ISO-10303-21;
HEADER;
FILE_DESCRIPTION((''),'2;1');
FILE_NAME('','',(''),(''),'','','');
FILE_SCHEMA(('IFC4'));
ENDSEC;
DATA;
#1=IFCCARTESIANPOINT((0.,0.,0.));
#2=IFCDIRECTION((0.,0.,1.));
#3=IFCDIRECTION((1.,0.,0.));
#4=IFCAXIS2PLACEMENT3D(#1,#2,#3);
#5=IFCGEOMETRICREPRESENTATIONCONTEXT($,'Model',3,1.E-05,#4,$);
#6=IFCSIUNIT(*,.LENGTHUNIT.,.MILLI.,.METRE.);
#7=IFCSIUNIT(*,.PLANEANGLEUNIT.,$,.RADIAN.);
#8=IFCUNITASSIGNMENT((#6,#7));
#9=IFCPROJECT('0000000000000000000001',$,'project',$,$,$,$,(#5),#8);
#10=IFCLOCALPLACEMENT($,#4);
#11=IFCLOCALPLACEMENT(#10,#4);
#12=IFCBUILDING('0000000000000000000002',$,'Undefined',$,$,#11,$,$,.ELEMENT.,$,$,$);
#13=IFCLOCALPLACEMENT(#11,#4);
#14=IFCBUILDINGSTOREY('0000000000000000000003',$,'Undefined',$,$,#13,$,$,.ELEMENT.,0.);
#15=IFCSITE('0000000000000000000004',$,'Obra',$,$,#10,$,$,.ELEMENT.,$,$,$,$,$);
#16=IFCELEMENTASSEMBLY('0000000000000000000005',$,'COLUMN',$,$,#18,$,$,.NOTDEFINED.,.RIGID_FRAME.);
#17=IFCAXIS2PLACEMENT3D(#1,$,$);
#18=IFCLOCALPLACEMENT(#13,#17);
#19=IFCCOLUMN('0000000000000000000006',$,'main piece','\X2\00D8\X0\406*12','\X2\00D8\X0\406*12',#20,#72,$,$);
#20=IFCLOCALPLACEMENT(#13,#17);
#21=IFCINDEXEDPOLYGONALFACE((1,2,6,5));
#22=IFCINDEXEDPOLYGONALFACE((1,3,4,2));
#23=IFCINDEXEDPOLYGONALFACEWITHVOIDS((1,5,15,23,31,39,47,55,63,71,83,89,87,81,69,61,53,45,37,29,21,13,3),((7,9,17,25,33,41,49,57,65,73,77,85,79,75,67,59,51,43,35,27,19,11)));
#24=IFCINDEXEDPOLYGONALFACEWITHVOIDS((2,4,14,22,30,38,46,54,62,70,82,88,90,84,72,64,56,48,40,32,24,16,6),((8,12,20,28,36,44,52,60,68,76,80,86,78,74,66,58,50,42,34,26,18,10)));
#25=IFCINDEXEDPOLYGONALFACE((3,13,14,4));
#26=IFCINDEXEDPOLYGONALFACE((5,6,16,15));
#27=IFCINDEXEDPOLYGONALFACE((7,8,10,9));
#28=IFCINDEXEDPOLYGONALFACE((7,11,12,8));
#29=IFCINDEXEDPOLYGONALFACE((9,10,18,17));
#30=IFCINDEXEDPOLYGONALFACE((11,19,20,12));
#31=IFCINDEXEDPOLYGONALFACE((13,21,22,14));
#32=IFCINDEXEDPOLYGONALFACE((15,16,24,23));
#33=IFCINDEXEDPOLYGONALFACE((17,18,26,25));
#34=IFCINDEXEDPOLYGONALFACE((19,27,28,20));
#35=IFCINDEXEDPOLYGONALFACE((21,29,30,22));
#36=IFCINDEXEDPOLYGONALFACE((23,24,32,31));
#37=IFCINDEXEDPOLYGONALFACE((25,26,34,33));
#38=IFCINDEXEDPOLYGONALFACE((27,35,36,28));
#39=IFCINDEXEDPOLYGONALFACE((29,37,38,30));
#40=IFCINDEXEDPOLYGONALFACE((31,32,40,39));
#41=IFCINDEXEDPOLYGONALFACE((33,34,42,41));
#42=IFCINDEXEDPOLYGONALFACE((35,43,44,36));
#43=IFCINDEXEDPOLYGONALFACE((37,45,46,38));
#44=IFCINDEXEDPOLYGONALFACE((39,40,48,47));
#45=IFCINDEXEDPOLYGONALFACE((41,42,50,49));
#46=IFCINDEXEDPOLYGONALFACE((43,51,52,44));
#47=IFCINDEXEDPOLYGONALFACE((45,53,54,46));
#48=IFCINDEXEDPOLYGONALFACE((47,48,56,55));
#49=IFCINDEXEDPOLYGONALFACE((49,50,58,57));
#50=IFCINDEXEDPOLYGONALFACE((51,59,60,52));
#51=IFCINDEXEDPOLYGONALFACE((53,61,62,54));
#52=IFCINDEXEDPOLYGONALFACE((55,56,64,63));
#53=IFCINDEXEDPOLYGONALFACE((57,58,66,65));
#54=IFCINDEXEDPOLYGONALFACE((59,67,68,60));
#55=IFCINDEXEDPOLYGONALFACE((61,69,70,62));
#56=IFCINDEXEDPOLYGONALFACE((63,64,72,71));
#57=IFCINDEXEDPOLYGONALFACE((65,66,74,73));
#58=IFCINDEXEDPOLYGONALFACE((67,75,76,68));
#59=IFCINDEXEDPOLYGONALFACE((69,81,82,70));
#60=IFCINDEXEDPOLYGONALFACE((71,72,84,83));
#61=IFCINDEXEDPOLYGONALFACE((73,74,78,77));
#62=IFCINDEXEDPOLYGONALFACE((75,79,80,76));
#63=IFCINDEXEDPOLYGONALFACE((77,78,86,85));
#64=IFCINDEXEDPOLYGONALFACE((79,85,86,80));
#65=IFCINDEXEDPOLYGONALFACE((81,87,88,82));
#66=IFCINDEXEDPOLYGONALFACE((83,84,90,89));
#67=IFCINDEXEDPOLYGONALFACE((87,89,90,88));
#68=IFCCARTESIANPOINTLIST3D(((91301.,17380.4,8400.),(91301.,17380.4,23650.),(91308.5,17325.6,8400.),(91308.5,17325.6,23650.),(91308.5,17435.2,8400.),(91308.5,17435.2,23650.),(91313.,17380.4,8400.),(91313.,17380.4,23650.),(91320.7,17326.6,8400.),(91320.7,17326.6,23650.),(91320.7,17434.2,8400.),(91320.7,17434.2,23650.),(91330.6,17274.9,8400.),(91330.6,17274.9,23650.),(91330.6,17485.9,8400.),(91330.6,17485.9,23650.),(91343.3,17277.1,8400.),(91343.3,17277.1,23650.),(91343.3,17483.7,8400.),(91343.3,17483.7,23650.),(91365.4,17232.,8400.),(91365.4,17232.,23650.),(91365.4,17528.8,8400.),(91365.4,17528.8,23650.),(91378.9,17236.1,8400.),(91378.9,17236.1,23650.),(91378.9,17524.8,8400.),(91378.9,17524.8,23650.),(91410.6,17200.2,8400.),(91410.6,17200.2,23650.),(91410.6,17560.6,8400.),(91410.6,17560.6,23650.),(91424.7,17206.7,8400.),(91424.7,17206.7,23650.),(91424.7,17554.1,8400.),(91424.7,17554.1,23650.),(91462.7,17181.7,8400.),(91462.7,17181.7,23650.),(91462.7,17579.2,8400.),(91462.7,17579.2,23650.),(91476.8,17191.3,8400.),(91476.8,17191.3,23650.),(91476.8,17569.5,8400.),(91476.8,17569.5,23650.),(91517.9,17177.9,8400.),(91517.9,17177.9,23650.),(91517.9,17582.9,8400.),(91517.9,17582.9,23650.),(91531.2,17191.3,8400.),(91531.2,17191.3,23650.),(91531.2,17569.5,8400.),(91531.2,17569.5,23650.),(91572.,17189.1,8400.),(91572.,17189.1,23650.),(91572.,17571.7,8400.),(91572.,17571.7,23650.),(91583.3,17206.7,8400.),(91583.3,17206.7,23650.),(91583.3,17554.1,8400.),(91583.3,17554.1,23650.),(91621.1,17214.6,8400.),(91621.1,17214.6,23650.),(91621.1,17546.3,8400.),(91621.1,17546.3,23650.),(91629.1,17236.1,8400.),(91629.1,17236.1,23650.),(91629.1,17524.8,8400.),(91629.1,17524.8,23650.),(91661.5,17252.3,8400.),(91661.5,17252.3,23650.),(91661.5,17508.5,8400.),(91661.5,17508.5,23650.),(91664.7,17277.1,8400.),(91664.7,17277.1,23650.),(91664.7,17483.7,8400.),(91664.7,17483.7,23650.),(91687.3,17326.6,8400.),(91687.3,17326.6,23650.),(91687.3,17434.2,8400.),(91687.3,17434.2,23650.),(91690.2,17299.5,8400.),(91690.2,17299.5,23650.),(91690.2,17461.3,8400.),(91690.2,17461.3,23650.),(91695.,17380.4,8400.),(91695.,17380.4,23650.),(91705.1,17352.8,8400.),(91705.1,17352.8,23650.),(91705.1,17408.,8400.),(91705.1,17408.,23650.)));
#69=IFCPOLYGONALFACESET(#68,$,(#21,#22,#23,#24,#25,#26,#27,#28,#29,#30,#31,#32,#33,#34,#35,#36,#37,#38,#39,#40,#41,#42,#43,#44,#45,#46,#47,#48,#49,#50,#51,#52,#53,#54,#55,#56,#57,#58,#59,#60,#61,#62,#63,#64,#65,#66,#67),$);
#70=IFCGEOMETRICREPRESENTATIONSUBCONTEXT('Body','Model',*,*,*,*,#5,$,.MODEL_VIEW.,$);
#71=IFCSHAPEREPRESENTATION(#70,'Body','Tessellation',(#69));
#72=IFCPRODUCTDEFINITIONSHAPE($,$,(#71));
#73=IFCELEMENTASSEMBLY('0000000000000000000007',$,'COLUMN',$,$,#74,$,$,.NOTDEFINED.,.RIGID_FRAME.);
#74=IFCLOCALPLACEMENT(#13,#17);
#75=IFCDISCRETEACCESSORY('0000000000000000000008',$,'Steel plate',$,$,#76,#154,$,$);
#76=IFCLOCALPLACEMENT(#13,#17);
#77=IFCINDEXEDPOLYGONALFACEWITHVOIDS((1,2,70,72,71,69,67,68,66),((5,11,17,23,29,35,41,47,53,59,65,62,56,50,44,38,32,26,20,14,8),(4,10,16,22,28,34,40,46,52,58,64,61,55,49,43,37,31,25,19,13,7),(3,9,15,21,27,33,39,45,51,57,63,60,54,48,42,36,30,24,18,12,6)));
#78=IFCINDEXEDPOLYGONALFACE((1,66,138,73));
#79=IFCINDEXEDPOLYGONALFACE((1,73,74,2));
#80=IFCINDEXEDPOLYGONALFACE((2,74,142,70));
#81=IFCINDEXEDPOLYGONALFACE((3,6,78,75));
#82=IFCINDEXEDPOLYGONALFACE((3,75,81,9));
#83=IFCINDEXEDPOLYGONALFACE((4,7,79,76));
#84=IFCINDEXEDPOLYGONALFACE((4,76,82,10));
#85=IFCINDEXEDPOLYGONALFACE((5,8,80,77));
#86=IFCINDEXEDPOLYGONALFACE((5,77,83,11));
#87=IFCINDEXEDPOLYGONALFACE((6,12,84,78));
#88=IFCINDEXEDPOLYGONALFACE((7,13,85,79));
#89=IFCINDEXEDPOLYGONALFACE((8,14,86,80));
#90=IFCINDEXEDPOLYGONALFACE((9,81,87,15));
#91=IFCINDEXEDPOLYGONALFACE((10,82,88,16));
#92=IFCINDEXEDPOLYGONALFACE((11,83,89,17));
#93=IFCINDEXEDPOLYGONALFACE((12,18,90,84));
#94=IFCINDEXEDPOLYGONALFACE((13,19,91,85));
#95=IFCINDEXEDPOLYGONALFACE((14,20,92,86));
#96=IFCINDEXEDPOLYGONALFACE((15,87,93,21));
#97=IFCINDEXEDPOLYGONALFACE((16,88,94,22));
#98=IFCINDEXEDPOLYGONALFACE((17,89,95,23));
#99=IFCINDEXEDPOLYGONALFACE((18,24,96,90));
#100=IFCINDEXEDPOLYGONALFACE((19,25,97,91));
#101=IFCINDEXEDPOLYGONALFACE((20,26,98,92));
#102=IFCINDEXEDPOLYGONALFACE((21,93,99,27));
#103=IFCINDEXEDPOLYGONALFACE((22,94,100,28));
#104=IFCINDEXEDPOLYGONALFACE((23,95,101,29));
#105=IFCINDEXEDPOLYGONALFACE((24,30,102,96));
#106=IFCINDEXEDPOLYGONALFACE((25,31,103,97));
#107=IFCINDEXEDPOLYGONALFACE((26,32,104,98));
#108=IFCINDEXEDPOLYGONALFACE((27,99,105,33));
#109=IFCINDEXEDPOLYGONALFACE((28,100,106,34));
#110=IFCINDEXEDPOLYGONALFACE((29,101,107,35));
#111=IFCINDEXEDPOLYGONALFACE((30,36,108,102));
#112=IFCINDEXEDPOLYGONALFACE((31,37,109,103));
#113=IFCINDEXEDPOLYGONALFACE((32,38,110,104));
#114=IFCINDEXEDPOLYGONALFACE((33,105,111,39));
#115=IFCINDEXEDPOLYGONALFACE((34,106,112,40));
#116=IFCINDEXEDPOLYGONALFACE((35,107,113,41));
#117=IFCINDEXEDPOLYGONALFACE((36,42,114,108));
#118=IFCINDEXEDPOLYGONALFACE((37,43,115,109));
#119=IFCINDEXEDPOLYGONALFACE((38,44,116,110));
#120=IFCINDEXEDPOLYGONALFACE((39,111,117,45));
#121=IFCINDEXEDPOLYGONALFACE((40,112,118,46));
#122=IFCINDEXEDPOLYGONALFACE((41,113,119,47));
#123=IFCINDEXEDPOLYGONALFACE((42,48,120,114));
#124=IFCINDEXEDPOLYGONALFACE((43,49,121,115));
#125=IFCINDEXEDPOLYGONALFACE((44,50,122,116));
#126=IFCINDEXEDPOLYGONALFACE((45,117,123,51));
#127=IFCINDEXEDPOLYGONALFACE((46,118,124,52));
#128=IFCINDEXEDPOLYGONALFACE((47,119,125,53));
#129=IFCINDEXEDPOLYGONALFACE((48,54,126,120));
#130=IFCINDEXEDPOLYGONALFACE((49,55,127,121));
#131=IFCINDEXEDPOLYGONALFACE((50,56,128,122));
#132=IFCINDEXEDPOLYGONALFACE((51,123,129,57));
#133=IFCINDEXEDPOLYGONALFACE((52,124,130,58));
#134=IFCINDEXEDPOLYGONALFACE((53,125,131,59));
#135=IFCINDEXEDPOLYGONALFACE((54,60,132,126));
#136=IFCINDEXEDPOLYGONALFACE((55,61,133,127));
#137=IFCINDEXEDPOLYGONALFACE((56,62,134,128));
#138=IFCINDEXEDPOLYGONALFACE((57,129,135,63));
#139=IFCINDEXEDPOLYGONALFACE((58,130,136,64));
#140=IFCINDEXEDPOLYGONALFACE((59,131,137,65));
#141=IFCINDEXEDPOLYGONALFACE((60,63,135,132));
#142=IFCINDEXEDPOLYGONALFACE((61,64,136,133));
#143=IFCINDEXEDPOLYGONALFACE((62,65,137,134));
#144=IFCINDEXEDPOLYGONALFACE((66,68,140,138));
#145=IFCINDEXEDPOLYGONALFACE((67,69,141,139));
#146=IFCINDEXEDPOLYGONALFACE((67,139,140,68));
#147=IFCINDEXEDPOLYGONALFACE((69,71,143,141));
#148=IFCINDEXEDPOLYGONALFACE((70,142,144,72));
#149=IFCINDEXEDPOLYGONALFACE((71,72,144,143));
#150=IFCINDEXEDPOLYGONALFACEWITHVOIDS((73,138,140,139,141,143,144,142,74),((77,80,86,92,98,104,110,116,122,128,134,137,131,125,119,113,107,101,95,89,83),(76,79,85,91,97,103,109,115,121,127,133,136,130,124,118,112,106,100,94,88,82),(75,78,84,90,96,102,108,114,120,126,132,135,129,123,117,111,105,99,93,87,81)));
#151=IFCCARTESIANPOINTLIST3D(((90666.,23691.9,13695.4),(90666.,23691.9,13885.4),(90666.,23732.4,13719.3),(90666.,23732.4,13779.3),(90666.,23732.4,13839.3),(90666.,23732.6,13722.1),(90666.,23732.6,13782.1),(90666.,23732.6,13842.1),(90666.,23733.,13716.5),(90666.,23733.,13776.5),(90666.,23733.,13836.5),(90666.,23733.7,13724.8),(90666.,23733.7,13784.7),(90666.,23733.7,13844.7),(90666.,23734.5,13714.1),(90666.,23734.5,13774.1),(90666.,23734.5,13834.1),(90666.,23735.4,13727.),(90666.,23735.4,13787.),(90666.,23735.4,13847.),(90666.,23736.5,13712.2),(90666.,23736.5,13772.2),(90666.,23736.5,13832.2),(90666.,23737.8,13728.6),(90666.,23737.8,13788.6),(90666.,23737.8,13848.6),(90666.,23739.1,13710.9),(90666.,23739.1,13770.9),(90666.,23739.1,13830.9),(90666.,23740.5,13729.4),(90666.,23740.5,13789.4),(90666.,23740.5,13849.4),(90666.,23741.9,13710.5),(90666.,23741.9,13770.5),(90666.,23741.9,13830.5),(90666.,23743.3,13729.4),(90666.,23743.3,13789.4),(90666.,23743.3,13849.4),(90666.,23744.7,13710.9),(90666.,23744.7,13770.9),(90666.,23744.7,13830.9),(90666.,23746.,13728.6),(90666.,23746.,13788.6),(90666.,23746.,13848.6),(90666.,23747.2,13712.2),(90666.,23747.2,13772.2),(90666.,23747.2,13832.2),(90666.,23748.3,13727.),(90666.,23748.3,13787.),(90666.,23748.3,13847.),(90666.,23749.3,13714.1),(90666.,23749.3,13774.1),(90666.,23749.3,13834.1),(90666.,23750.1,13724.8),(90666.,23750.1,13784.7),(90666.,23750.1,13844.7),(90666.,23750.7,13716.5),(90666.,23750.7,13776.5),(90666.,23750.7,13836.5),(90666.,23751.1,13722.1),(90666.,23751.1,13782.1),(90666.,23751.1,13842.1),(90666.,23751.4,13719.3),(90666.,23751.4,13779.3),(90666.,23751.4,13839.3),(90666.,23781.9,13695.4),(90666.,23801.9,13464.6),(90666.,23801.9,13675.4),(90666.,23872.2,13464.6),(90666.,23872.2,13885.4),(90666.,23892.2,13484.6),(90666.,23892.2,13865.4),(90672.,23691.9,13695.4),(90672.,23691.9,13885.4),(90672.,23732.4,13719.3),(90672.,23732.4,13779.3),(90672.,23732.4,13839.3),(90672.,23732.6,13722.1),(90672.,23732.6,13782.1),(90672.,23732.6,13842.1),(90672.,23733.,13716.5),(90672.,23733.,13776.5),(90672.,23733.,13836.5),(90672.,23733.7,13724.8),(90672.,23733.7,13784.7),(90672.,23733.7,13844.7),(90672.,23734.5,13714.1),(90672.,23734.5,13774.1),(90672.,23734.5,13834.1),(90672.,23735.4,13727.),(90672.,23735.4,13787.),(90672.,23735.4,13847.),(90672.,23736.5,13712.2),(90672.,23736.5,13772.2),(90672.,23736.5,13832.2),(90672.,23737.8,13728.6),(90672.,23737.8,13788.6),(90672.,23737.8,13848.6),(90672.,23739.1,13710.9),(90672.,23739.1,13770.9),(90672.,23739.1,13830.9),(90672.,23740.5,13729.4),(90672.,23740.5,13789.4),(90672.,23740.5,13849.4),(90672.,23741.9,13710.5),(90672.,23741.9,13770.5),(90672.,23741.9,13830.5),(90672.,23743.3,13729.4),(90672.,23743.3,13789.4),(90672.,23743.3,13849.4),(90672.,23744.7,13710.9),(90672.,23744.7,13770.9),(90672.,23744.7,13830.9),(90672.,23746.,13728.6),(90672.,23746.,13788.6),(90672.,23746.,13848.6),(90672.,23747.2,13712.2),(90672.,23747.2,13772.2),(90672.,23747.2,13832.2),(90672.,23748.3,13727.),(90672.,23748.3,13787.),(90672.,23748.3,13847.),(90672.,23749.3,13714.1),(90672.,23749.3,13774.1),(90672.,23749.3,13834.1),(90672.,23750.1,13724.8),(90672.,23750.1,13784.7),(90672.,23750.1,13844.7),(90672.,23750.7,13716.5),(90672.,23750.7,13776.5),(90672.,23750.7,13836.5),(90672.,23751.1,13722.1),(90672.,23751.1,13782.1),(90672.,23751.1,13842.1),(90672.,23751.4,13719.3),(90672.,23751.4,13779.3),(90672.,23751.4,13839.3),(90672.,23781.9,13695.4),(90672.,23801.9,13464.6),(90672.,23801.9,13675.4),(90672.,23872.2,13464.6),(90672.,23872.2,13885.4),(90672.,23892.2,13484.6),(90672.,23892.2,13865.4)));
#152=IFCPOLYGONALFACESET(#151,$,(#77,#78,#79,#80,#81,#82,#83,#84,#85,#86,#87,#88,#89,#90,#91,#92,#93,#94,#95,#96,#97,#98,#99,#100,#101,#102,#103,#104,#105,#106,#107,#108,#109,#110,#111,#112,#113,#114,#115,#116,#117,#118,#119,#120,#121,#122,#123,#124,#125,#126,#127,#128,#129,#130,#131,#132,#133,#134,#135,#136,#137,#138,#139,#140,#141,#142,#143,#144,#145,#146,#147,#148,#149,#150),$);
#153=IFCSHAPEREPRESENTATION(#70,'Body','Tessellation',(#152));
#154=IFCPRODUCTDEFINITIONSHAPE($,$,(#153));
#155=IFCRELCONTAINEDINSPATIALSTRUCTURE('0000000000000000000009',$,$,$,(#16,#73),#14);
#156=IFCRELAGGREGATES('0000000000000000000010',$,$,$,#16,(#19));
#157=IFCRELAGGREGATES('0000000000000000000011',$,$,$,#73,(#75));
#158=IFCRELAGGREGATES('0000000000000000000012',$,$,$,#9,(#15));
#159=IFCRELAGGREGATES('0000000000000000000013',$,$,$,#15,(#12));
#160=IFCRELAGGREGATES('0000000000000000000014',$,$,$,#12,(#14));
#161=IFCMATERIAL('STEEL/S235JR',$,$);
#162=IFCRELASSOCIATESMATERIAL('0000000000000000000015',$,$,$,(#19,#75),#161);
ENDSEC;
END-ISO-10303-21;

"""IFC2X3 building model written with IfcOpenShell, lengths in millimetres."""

from ifc_helpers import new_model, si_unit, frame, origin_with_axes, origin_2d_with_axis, place, context, subcontext, project, spatial, polyline, circle, hollow_circle, outline, extrude, clip, halfspace, source, transform, mapped, material, element, aggregate, save


model = new_model("IFC2X3")

# Units and contexts
model_context = context("Model", 3, precision=1e-05, world=origin_with_axes())
body_context = subcontext(model_context, "Body", "Model", "MODEL_VIEW")
ifc_project = project(units=[si_unit("LENGTHUNIT", "METRE", prefix="MILLI"), si_unit("PLANEANGLEUNIT", "RADIAN")], contexts=[model_context])

# Site, building, storey
site_placement = place(None, origin_with_axes())
site = spatial("IfcSite", under=ifc_project, at=site_placement, Name="Obra", CompositionType="ELEMENT")
building_placement = place(site_placement, origin_with_axes())
building = spatial("IfcBuilding", under=site, at=building_placement, Name="Undefined", CompositionType="ELEMENT")
storey_placement = place(building_placement, origin_with_axes())
storey = spatial("IfcBuildingStorey", under=building, at=storey_placement, Name="Undefined", CompositionType="ELEMENT", Elevation=0.0)

# Element assembly, column
assembly_1_placement = place(storey_placement, origin_with_axes())
assembly_1 = element("IfcElementAssembly", 1, at=assembly_1_placement, inside=storey, Name="COLUMN", AssemblyPlace="NOTDEFINED", PredefinedType="RIGID_FRAME")
ifc_material_1 = material(Name="STEEL/S235JR")
column_placement = place(assembly_1_placement, frame((91504.0, 17380.4, 8384.0), z_axis=(0.0, 0.0, 1.0), x_axis=(0.0, 1.0, 0.0)))
column = element("IfcColumn", 2, at=column_placement, material=ifc_material_1, Name="main piece", Description="Ø406*12", ObjectType="Ø406*12", context=body_context, shape_type="Clipping", body=[
    clip(extrude(hollow_circle(Radius=203.0, WallThickness=12.0, at=origin_2d_with_axis()), frame((0.0, 0.0, 15266.0), z_axis=(0.0, 0.0, -1.0), x_axis=(0.0, 1.0, 0.0)), (0.0, 0.0, 1.0), 15250.0), halfspace(frame((-203.0, 0.0, 16.0), z_axis=(0.0, 0.0, 1.0), x_axis=(0.0, 1.0, 0.0)), True)),
])

# Element assembly, discrete accessory, opening
assembly_2_placement = place(storey_placement, origin_with_axes())
assembly_2 = element("IfcElementAssembly", 3, at=assembly_2_placement, inside=storey, Name="COLUMN", AssemblyPlace="NOTDEFINED", PredefinedType="RIGID_FRAME")
discrete_accessory_1_placement = place(assembly_2_placement, frame((90669.0, 23892.2, 13484.6), z_axis=(-1.0, 0.0, 0.0), x_axis=(0.0, -0.707107, -0.707107)))
discrete_accessory_1 = element("IfcDiscreteAccessory", 4, at=discrete_accessory_1_placement, material=ifc_material_1, Name="Steel plate", context=body_context, shape_type="SweptSolid", body=[
    extrude(outline(polyline([(0.0, 0.0), (28.3, 0.0), (78.0, 49.7), (-71.1, 198.8), (-71.1, 227.1), (-7.4, 290.7), (-141.8, 425.0), (-269.3, 297.6), (-269.3, 269.3), (0.0, 0.0)])), frame((0.0, 0.0, -3.0), z_axis=(0.0, 0.0, 1.0), x_axis=(1.0, 0.0, 0.0)), (0.0, 0.0, 1.0), 6.0),
])
shared_shape_1 = source(origin_with_axes(), body_context, "Body", "SweptSolid", [
    extrude(circle(Radius=9.5, at=origin_2d_with_axis()), frame((0.0, -9.2, 0.0), z_axis=(0.0, 1.0, 0.0), x_axis=(1.0, 0.0, 0.0)), (0.0, 0.0, 1.0), 6.2),
])
opening_1_placement = place(assembly_2_placement, frame((90675.1, 23791.9, 13885.4), z_axis=(0.0, -1.0, 0.0), x_axis=(0.0, 0.0, -1.0)))
element("IfcOpeningElement", 5, at=opening_1_placement, cuts=discrete_accessory_1, ObjectType="Opening", context=body_context, shape_type="MappedRepresentation", body=[
    mapped(shared_shape_1, transform((165.4, 0.0, 50.0))),
    mapped(shared_shape_1, transform((105.4, 0.0, 50.0))),
    mapped(shared_shape_1, transform((45.4, 0.0, 50.0))),
])

aggregate(assembly_1, [column])
aggregate(assembly_2, [discrete_accessory_1])

save(model, "model.ifc")
